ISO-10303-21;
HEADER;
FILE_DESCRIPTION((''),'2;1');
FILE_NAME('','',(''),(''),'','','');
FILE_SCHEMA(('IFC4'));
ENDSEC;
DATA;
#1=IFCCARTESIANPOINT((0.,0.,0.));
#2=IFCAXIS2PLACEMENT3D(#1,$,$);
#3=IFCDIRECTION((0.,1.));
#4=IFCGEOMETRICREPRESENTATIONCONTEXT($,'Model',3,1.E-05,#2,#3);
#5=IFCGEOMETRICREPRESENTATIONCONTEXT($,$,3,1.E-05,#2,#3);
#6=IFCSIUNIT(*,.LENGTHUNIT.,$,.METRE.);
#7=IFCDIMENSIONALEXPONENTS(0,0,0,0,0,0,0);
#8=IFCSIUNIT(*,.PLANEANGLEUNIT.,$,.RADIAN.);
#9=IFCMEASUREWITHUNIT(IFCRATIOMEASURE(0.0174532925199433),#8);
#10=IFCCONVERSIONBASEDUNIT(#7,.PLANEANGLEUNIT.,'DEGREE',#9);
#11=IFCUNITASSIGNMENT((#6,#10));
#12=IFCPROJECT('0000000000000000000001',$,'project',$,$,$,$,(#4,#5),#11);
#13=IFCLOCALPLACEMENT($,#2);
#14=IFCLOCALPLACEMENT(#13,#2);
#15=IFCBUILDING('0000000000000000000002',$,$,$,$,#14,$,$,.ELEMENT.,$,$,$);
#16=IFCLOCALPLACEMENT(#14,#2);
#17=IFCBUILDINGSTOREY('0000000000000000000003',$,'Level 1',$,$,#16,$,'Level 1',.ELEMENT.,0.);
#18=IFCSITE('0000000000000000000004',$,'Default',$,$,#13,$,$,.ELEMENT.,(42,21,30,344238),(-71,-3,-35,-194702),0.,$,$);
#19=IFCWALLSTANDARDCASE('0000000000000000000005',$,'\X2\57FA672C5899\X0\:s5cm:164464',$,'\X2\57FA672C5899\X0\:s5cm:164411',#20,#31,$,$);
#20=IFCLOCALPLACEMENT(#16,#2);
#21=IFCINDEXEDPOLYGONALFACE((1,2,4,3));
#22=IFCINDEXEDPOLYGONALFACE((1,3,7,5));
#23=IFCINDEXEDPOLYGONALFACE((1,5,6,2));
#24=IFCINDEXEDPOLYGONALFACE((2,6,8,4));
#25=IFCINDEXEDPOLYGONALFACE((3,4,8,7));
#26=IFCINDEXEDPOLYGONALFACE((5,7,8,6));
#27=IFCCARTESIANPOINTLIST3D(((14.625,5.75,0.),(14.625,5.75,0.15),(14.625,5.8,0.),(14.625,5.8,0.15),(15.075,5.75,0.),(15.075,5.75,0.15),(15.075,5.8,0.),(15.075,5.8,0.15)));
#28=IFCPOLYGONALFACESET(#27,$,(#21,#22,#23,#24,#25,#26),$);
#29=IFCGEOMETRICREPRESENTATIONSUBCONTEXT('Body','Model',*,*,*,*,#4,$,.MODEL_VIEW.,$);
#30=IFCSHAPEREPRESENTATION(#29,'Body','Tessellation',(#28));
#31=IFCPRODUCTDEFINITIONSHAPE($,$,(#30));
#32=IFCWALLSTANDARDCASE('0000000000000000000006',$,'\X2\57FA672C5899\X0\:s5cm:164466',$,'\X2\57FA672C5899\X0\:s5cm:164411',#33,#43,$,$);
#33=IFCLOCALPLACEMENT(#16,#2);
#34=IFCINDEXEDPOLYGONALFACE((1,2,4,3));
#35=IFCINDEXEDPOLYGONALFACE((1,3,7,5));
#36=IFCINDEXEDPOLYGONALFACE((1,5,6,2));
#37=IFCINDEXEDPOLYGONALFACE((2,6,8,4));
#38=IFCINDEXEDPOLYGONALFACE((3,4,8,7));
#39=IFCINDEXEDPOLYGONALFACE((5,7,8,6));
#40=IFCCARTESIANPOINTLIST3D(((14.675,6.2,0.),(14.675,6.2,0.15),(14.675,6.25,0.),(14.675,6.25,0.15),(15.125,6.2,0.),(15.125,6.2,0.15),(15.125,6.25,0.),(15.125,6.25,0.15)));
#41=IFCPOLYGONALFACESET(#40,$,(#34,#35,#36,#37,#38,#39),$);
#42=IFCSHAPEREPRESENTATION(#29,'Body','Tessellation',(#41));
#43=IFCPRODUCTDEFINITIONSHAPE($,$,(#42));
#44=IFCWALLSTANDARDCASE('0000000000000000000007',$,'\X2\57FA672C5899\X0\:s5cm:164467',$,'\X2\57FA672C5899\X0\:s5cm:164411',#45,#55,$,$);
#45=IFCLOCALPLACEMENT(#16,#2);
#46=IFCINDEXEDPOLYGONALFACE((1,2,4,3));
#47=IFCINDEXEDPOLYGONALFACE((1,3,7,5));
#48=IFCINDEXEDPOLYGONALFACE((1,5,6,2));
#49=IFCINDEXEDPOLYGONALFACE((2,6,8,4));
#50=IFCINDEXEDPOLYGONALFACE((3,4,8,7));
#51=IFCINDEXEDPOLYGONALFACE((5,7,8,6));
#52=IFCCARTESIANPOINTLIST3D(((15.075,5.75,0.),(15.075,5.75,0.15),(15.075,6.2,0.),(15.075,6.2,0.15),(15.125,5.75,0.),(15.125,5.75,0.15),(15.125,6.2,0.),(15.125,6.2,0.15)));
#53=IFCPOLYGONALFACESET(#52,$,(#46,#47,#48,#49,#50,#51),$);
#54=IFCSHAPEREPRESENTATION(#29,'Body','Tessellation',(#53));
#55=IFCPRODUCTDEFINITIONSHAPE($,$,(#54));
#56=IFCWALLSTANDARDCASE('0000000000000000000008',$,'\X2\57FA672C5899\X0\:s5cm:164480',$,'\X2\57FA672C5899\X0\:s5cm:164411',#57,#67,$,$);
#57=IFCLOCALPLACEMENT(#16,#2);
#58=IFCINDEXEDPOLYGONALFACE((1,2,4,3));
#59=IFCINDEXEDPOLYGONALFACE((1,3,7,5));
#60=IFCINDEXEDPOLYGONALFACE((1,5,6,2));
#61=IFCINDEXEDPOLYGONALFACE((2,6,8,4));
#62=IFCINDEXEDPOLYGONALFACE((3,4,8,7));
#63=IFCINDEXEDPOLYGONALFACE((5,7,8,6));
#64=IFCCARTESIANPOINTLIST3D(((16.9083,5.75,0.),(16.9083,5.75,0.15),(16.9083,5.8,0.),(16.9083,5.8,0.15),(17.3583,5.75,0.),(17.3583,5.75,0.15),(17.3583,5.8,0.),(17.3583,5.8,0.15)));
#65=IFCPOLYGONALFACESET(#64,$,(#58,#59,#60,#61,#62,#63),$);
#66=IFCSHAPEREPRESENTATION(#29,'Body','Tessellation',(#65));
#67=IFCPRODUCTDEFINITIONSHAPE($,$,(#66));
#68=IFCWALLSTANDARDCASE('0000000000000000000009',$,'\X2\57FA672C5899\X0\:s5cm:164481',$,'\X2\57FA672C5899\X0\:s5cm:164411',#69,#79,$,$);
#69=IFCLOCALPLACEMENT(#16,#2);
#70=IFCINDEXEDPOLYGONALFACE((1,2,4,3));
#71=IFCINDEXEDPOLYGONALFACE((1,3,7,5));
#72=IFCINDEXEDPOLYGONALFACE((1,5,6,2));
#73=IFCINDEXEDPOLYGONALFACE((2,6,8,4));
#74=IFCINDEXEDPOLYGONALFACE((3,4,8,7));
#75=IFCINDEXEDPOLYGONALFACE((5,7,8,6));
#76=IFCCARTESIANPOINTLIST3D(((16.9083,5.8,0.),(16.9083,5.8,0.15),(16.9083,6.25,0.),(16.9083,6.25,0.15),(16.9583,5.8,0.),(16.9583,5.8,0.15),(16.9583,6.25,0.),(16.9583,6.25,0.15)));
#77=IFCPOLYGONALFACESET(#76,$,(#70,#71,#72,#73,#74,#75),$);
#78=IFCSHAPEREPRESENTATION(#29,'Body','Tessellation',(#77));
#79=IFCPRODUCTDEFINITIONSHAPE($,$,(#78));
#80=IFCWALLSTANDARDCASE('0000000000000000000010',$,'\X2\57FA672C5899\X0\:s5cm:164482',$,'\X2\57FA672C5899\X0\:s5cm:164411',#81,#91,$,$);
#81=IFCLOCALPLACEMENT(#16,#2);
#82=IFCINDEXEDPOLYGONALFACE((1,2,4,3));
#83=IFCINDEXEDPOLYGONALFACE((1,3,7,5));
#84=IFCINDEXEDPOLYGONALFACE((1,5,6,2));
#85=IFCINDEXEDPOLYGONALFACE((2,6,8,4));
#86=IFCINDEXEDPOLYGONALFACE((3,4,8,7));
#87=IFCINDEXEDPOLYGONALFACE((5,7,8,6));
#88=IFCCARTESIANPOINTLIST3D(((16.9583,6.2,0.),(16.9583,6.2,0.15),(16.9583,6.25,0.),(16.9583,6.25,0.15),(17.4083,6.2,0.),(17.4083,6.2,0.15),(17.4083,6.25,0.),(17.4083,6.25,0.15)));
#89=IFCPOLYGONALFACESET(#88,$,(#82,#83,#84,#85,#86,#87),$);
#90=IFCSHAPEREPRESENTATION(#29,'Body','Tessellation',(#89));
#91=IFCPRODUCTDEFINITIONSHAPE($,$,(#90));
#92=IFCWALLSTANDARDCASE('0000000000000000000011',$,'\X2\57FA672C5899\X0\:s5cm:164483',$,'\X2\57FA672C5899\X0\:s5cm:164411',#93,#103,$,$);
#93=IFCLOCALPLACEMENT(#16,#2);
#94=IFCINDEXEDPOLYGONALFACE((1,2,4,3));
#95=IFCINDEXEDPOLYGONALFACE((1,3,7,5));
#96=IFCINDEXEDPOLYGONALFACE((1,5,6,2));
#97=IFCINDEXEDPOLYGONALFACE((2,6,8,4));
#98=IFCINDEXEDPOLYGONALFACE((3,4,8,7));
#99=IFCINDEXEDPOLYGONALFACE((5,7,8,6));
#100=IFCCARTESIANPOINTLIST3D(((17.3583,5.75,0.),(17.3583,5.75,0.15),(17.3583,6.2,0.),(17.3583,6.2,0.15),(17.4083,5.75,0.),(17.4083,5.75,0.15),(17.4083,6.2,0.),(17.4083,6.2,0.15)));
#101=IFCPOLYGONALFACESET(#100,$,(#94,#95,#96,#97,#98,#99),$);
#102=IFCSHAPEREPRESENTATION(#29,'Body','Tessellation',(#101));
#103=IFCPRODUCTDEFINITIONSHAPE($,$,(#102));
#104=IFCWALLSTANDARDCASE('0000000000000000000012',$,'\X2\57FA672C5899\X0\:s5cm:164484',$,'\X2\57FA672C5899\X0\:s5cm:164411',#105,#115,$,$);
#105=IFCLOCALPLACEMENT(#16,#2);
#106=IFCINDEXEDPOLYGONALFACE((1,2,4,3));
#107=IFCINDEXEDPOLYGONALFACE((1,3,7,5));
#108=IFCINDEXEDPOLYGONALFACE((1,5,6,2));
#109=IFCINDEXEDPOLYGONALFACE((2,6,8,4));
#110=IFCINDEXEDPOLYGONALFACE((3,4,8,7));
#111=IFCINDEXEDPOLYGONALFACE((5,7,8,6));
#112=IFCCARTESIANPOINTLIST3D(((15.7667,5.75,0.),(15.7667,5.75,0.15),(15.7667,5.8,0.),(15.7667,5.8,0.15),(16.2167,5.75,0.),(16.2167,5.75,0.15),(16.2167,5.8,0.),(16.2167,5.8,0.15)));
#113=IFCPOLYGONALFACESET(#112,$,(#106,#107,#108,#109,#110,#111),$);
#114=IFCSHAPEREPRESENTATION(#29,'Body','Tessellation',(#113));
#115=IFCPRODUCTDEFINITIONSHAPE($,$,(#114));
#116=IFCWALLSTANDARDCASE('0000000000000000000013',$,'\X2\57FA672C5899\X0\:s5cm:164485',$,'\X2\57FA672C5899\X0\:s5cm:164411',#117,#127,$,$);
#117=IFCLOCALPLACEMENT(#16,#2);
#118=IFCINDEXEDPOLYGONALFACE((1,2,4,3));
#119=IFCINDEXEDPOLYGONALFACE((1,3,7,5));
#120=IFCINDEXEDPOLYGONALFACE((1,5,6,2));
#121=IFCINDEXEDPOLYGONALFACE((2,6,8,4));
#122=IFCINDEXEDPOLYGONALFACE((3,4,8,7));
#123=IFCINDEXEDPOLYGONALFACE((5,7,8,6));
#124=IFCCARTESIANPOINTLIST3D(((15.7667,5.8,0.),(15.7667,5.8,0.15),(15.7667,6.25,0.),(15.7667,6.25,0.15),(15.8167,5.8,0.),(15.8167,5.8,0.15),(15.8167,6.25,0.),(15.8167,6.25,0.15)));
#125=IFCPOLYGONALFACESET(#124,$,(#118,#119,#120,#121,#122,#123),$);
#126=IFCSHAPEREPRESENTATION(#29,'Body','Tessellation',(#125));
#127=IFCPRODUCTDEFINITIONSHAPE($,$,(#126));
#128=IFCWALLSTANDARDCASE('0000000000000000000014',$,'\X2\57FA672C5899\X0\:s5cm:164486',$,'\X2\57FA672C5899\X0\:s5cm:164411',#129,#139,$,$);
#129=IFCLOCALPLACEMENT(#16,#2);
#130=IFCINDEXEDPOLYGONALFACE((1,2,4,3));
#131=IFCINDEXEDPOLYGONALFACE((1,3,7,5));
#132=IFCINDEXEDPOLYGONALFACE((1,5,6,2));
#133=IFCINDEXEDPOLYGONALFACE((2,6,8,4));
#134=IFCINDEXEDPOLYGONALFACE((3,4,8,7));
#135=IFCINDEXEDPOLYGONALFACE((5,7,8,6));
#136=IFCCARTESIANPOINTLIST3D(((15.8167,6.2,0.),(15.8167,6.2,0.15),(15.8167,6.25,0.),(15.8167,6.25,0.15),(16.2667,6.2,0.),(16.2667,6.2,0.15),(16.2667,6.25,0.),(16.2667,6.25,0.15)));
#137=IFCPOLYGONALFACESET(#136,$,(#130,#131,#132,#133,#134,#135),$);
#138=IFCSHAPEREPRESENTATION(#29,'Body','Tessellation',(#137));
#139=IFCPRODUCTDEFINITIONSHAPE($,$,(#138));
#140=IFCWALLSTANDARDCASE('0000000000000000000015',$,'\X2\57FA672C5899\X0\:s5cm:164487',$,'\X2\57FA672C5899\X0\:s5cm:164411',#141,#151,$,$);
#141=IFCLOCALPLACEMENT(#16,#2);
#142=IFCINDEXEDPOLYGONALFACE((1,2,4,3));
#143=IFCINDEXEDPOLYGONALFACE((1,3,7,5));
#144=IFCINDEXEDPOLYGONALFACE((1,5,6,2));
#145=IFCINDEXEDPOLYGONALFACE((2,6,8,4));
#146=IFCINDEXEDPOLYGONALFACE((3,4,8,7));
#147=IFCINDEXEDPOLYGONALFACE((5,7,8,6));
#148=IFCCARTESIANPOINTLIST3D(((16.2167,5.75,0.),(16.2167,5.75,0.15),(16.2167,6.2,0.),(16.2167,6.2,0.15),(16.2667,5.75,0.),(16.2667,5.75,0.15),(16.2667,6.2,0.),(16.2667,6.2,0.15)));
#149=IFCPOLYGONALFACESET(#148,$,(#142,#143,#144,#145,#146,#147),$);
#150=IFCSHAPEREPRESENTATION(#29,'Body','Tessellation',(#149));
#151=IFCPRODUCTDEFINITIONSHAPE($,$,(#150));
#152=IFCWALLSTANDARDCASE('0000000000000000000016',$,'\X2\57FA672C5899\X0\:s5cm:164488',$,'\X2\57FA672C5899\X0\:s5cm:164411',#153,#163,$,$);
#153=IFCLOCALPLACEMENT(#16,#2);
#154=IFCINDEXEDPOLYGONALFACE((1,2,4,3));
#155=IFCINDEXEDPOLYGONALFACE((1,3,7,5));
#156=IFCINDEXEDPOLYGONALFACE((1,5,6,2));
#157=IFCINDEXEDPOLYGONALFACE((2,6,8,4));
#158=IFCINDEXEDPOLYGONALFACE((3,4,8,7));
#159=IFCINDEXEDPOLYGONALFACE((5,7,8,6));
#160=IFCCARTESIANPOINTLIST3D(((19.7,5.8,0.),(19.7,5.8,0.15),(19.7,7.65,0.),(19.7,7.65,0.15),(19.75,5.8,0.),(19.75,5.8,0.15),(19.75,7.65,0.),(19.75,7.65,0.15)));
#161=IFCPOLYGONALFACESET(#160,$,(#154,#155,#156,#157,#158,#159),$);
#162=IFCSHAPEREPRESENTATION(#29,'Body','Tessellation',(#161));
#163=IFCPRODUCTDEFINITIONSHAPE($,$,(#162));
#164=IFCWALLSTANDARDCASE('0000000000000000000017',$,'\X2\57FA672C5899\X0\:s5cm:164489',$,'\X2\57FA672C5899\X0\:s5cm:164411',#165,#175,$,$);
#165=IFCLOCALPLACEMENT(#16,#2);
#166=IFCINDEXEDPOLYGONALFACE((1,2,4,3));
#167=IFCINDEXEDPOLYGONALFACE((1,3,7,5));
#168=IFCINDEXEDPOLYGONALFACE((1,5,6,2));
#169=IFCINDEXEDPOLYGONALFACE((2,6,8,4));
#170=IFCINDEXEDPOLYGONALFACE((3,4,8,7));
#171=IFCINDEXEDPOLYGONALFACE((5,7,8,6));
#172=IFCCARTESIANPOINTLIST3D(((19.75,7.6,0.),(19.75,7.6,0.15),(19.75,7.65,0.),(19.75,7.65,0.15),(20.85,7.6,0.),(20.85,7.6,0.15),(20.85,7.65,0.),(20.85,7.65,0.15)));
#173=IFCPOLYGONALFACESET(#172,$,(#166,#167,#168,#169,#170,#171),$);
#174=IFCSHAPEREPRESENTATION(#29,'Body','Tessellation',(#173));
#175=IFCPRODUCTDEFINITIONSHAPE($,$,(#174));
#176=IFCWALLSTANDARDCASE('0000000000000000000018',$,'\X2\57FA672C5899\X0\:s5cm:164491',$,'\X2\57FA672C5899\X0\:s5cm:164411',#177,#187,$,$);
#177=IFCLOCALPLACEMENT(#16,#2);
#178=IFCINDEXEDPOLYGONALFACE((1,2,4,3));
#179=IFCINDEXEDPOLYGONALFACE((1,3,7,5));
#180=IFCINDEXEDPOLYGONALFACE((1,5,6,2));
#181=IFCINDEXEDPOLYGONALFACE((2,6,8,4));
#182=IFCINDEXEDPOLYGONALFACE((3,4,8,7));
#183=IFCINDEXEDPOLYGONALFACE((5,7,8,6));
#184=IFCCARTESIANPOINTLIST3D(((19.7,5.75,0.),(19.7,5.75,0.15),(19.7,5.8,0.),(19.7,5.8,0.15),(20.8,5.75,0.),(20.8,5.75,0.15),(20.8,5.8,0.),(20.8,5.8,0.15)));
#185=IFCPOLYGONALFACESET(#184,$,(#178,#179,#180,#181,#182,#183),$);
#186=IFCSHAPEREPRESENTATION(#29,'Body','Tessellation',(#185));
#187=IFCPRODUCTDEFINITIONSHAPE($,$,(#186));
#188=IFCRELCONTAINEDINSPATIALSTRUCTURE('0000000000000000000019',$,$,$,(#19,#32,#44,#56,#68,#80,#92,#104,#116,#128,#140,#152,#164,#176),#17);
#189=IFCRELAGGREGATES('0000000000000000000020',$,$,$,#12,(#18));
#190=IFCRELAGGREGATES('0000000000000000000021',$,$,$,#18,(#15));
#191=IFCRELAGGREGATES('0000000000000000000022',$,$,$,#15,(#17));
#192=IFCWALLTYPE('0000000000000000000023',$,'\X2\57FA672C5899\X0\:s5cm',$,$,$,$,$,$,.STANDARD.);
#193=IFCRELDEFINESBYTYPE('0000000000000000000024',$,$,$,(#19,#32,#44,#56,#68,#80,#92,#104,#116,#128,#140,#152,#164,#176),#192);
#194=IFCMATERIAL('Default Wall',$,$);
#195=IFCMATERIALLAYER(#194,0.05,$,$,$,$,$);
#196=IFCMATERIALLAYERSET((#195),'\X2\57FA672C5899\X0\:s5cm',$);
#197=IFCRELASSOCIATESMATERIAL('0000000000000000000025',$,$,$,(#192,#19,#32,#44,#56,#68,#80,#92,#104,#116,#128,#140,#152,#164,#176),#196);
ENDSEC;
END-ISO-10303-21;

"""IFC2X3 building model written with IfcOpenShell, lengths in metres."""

from ifc_helpers import new_model, entity, si_unit, converted_unit, direction, frame, frame_2d, origin, place, context, subcontext, project, spatial, rectangle, extrude, material, layer, layer_set, layer_usage, type_object, element, save


model = new_model("IFC2X3")

# Units and contexts
model_context = context("Model", 3, precision=1e-05, world=origin(), true_north=direction((0.0, 1.0)))
context_of_model = context(None, 3, precision=1e-05, world=origin(), true_north=direction((0.0, 1.0)))
body_context = subcontext(model_context, "Body", "Model", "MODEL_VIEW")
ifc_project = project(units=[si_unit("LENGTHUNIT", "METRE"), converted_unit("PLANEANGLEUNIT", "DEGREE", entity("IfcRatioMeasure", 0.0174532925199433), si_unit("PLANEANGLEUNIT", "RADIAN"), dimensions=[0, 0, 0, 0, 0, 0, 0])], contexts=[model_context, context_of_model])

# Site, building, storey
site_placement = place(None, origin())
site = spatial("IfcSite", under=ifc_project, at=site_placement, Name="Default", CompositionType="ELEMENT", RefLatitude=(42, 21, 30, 344238), RefLongitude=(-71, -3, -35, -194702), RefElevation=0.0)
building_placement = place(site_placement, origin())
building = spatial("IfcBuilding", under=site, at=building_placement, CompositionType="ELEMENT")
storey_placement = place(building_placement, origin())
storey = spatial("IfcBuildingStorey", under=building, at=storey_placement, Name="Level 1", LongName="Level 1", CompositionType="ELEMENT", Elevation=0.0)

# Walls
ifc_material_1 = material(Name="Default Wall")
ifc_layer_1 = layer(ifc_material_1, 0.05)
ifc_layer_set_1 = layer_set([ifc_layer_1], Name="基本墙:s5cm")
wall_type = type_object("IfcWallType", Name="基本墙:s5cm", PredefinedType="STANDARD", material=ifc_layer_set_1)
ifc_layer_usage_1 = layer_usage(ifc_layer_set_1, "AXIS2", "NEGATIVE", 0.025)
wall_1_placement = place(storey_placement, frame((15.075, 5.775, 0.0), z_axis=(0.0, 0.0, 1.0), x_axis=(-1.0, 0.0, 0.0)))
element("IfcWallStandardCase", 1, at=wall_1_placement, inside=storey, type_object=wall_type, material=ifc_layer_usage_1, Name="基本墙:s5cm:164464", ObjectType="基本墙:s5cm:164411", context=body_context, shape_type="SweptSolid", body=[
    extrude(rectangle(XDim=0.45, YDim=0.05, at=frame_2d((0.225, 0.0), x_axis=(-1.0, 0.0))), origin(), (0.0, 0.0, 1.0), 0.15),
])
ifc_layer_usage_2 = layer_usage(ifc_layer_set_1, "AXIS2", "NEGATIVE", 0.025)
wall_2_placement = place(storey_placement, frame((14.675, 6.225, 0.0)))
element("IfcWallStandardCase", 2, at=wall_2_placement, inside=storey, type_object=wall_type, material=ifc_layer_usage_2, Name="基本墙:s5cm:164466", ObjectType="基本墙:s5cm:164411", context=body_context, shape_type="SweptSolid", body=[
    extrude(rectangle(XDim=0.45, YDim=0.05, at=frame_2d((0.225, 0.0), x_axis=(-1.0, 0.0))), origin(), (0.0, 0.0, 1.0), 0.15),
])
ifc_layer_usage_3 = layer_usage(ifc_layer_set_1, "AXIS2", "NEGATIVE", 0.025)
wall_3_placement = place(storey_placement, frame((15.1, 6.2, 0.0), z_axis=(0.0, 0.0, 1.0), x_axis=(0.0, -1.0, 0.0)))
element("IfcWallStandardCase", 3, at=wall_3_placement, inside=storey, type_object=wall_type, material=ifc_layer_usage_3, Name="基本墙:s5cm:164467", ObjectType="基本墙:s5cm:164411", context=body_context, shape_type="SweptSolid", body=[
    extrude(rectangle(XDim=0.45, YDim=0.05, at=frame_2d((0.225, 0.0), x_axis=(-1.0, 0.0))), origin(), (0.0, 0.0, 1.0), 0.15),
])
ifc_layer_usage_4 = layer_usage(ifc_layer_set_1, "AXIS2", "NEGATIVE", 0.025)
wall_4_placement = place(storey_placement, frame((17.3583, 5.775, 0.0), z_axis=(0.0, 0.0, 1.0), x_axis=(-1.0, 0.0, 0.0)))
element("IfcWallStandardCase", 4, at=wall_4_placement, inside=storey, type_object=wall_type, material=ifc_layer_usage_4, Name="基本墙:s5cm:164480", ObjectType="基本墙:s5cm:164411", context=body_context, shape_type="SweptSolid", body=[
    extrude(rectangle(XDim=0.45, YDim=0.05, at=frame_2d((0.225, 0.0), x_axis=(-1.0, 0.0))), origin(), (0.0, 0.0, 1.0), 0.15),
])
ifc_layer_usage_5 = layer_usage(ifc_layer_set_1, "AXIS2", "NEGATIVE", 0.025)
wall_5_placement = place(storey_placement, frame((16.9333, 5.8, 0.0), z_axis=(0.0, 0.0, 1.0), x_axis=(0.0, 1.0, 0.0)))
element("IfcWallStandardCase", 5, at=wall_5_placement, inside=storey, type_object=wall_type, material=ifc_layer_usage_5, Name="基本墙:s5cm:164481", ObjectType="基本墙:s5cm:164411", context=body_context, shape_type="SweptSolid", body=[
    extrude(rectangle(XDim=0.45, YDim=0.05, at=frame_2d((0.225, 0.0), x_axis=(-1.0, 0.0))), origin(), (0.0, 0.0, 1.0), 0.15),
])
ifc_layer_usage_6 = layer_usage(ifc_layer_set_1, "AXIS2", "NEGATIVE", 0.025)
wall_6_placement = place(storey_placement, frame((16.9583, 6.225, 0.0)))
element("IfcWallStandardCase", 6, at=wall_6_placement, inside=storey, type_object=wall_type, material=ifc_layer_usage_6, Name="基本墙:s5cm:164482", ObjectType="基本墙:s5cm:164411", context=body_context, shape_type="SweptSolid", body=[
    extrude(rectangle(XDim=0.45, YDim=0.05, at=frame_2d((0.225, 0.0), x_axis=(-1.0, 0.0))), origin(), (0.0, 0.0, 1.0), 0.15),
])
ifc_layer_usage_7 = layer_usage(ifc_layer_set_1, "AXIS2", "NEGATIVE", 0.025)
wall_7_placement = place(storey_placement, frame((17.3833, 6.2, 0.0), z_axis=(0.0, 0.0, 1.0), x_axis=(0.0, -1.0, 0.0)))
element("IfcWallStandardCase", 7, at=wall_7_placement, inside=storey, type_object=wall_type, material=ifc_layer_usage_7, Name="基本墙:s5cm:164483", ObjectType="基本墙:s5cm:164411", context=body_context, shape_type="SweptSolid", body=[
    extrude(rectangle(XDim=0.45, YDim=0.05, at=frame_2d((0.225, 0.0), x_axis=(-1.0, 0.0))), origin(), (0.0, 0.0, 1.0), 0.15),
])
ifc_layer_usage_8 = layer_usage(ifc_layer_set_1, "AXIS2", "NEGATIVE", 0.025)
wall_8_placement = place(storey_placement, frame((16.2167, 5.775, 0.0), z_axis=(0.0, 0.0, 1.0), x_axis=(-1.0, 0.0, 0.0)))
element("IfcWallStandardCase", 8, at=wall_8_placement, inside=storey, type_object=wall_type, material=ifc_layer_usage_8, Name="基本墙:s5cm:164484", ObjectType="基本墙:s5cm:164411", context=body_context, shape_type="SweptSolid", body=[
    extrude(rectangle(XDim=0.45, YDim=0.05, at=frame_2d((0.225, 0.0), x_axis=(-1.0, 0.0))), origin(), (0.0, 0.0, 1.0), 0.15),
])
ifc_layer_usage_9 = layer_usage(ifc_layer_set_1, "AXIS2", "NEGATIVE", 0.025)
wall_9_placement = place(storey_placement, frame((15.7917, 5.8, 0.0), z_axis=(0.0, 0.0, 1.0), x_axis=(0.0, 1.0, 0.0)))
element("IfcWallStandardCase", 9, at=wall_9_placement, inside=storey, type_object=wall_type, material=ifc_layer_usage_9, Name="基本墙:s5cm:164485", ObjectType="基本墙:s5cm:164411", context=body_context, shape_type="SweptSolid", body=[
    extrude(rectangle(XDim=0.45, YDim=0.05, at=frame_2d((0.225, 0.0), x_axis=(-1.0, 0.0))), origin(), (0.0, 0.0, 1.0), 0.15),
])
ifc_layer_usage_10 = layer_usage(ifc_layer_set_1, "AXIS2", "NEGATIVE", 0.025)
wall_10_placement = place(storey_placement, frame((15.8167, 6.225, 0.0)))
element("IfcWallStandardCase", 10, at=wall_10_placement, inside=storey, type_object=wall_type, material=ifc_layer_usage_10, Name="基本墙:s5cm:164486", ObjectType="基本墙:s5cm:164411", context=body_context, shape_type="SweptSolid", body=[
    extrude(rectangle(XDim=0.45, YDim=0.05, at=frame_2d((0.225, 0.0), x_axis=(-1.0, 0.0))), origin(), (0.0, 0.0, 1.0), 0.15),
])
ifc_layer_usage_11 = layer_usage(ifc_layer_set_1, "AXIS2", "NEGATIVE", 0.025)
wall_11_placement = place(storey_placement, frame((16.2417, 6.2, 0.0), z_axis=(0.0, 0.0, 1.0), x_axis=(0.0, -1.0, 0.0)))
element("IfcWallStandardCase", 11, at=wall_11_placement, inside=storey, type_object=wall_type, material=ifc_layer_usage_11, Name="基本墙:s5cm:164487", ObjectType="基本墙:s5cm:164411", context=body_context, shape_type="SweptSolid", body=[
    extrude(rectangle(XDim=0.45, YDim=0.05, at=frame_2d((0.225, 0.0), x_axis=(-1.0, 0.0))), origin(), (0.0, 0.0, 1.0), 0.15),
])
ifc_layer_usage_12 = layer_usage(ifc_layer_set_1, "AXIS2", "NEGATIVE", 0.025)
wall_12_placement = place(storey_placement, frame((19.725, 5.8, 0.0), z_axis=(0.0, 0.0, 1.0), x_axis=(0.0, 1.0, 0.0)))
element("IfcWallStandardCase", 12, at=wall_12_placement, inside=storey, type_object=wall_type, material=ifc_layer_usage_12, Name="基本墙:s5cm:164488", ObjectType="基本墙:s5cm:164411", context=body_context, shape_type="SweptSolid", body=[
    extrude(rectangle(XDim=1.85, YDim=0.05, at=frame_2d((0.925, 0.0), x_axis=(-1.0, 0.0))), origin(), (0.0, 0.0, 1.0), 0.15),
])
ifc_layer_usage_13 = layer_usage(ifc_layer_set_1, "AXIS2", "NEGATIVE", 0.025)
wall_13_placement = place(storey_placement, frame((19.75, 7.625, 0.0)))
element("IfcWallStandardCase", 13, at=wall_13_placement, inside=storey, type_object=wall_type, material=ifc_layer_usage_13, Name="基本墙:s5cm:164489", ObjectType="基本墙:s5cm:164411", context=body_context, shape_type="SweptSolid", body=[
    extrude(rectangle(XDim=1.1, YDim=0.05, at=frame_2d((0.55, 0.0), x_axis=(-1.0, 0.0))), origin(), (0.0, 0.0, 1.0), 0.15),
])
ifc_layer_usage_14 = layer_usage(ifc_layer_set_1, "AXIS2", "NEGATIVE", 0.025)
wall_14_placement = place(storey_placement, frame((20.8, 5.775, 0.0), z_axis=(0.0, 0.0, 1.0), x_axis=(-1.0, 0.0, 0.0)))
element("IfcWallStandardCase", 14, at=wall_14_placement, inside=storey, type_object=wall_type, material=ifc_layer_usage_14, Name="基本墙:s5cm:164491", ObjectType="基本墙:s5cm:164411", context=body_context, shape_type="SweptSolid", body=[
    extrude(rectangle(XDim=1.1, YDim=0.05, at=frame_2d((0.55, 0.0), x_axis=(-1.0, 0.0))), origin(), (0.0, 0.0, 1.0), 0.15),
])

save(model, "model.ifc")
